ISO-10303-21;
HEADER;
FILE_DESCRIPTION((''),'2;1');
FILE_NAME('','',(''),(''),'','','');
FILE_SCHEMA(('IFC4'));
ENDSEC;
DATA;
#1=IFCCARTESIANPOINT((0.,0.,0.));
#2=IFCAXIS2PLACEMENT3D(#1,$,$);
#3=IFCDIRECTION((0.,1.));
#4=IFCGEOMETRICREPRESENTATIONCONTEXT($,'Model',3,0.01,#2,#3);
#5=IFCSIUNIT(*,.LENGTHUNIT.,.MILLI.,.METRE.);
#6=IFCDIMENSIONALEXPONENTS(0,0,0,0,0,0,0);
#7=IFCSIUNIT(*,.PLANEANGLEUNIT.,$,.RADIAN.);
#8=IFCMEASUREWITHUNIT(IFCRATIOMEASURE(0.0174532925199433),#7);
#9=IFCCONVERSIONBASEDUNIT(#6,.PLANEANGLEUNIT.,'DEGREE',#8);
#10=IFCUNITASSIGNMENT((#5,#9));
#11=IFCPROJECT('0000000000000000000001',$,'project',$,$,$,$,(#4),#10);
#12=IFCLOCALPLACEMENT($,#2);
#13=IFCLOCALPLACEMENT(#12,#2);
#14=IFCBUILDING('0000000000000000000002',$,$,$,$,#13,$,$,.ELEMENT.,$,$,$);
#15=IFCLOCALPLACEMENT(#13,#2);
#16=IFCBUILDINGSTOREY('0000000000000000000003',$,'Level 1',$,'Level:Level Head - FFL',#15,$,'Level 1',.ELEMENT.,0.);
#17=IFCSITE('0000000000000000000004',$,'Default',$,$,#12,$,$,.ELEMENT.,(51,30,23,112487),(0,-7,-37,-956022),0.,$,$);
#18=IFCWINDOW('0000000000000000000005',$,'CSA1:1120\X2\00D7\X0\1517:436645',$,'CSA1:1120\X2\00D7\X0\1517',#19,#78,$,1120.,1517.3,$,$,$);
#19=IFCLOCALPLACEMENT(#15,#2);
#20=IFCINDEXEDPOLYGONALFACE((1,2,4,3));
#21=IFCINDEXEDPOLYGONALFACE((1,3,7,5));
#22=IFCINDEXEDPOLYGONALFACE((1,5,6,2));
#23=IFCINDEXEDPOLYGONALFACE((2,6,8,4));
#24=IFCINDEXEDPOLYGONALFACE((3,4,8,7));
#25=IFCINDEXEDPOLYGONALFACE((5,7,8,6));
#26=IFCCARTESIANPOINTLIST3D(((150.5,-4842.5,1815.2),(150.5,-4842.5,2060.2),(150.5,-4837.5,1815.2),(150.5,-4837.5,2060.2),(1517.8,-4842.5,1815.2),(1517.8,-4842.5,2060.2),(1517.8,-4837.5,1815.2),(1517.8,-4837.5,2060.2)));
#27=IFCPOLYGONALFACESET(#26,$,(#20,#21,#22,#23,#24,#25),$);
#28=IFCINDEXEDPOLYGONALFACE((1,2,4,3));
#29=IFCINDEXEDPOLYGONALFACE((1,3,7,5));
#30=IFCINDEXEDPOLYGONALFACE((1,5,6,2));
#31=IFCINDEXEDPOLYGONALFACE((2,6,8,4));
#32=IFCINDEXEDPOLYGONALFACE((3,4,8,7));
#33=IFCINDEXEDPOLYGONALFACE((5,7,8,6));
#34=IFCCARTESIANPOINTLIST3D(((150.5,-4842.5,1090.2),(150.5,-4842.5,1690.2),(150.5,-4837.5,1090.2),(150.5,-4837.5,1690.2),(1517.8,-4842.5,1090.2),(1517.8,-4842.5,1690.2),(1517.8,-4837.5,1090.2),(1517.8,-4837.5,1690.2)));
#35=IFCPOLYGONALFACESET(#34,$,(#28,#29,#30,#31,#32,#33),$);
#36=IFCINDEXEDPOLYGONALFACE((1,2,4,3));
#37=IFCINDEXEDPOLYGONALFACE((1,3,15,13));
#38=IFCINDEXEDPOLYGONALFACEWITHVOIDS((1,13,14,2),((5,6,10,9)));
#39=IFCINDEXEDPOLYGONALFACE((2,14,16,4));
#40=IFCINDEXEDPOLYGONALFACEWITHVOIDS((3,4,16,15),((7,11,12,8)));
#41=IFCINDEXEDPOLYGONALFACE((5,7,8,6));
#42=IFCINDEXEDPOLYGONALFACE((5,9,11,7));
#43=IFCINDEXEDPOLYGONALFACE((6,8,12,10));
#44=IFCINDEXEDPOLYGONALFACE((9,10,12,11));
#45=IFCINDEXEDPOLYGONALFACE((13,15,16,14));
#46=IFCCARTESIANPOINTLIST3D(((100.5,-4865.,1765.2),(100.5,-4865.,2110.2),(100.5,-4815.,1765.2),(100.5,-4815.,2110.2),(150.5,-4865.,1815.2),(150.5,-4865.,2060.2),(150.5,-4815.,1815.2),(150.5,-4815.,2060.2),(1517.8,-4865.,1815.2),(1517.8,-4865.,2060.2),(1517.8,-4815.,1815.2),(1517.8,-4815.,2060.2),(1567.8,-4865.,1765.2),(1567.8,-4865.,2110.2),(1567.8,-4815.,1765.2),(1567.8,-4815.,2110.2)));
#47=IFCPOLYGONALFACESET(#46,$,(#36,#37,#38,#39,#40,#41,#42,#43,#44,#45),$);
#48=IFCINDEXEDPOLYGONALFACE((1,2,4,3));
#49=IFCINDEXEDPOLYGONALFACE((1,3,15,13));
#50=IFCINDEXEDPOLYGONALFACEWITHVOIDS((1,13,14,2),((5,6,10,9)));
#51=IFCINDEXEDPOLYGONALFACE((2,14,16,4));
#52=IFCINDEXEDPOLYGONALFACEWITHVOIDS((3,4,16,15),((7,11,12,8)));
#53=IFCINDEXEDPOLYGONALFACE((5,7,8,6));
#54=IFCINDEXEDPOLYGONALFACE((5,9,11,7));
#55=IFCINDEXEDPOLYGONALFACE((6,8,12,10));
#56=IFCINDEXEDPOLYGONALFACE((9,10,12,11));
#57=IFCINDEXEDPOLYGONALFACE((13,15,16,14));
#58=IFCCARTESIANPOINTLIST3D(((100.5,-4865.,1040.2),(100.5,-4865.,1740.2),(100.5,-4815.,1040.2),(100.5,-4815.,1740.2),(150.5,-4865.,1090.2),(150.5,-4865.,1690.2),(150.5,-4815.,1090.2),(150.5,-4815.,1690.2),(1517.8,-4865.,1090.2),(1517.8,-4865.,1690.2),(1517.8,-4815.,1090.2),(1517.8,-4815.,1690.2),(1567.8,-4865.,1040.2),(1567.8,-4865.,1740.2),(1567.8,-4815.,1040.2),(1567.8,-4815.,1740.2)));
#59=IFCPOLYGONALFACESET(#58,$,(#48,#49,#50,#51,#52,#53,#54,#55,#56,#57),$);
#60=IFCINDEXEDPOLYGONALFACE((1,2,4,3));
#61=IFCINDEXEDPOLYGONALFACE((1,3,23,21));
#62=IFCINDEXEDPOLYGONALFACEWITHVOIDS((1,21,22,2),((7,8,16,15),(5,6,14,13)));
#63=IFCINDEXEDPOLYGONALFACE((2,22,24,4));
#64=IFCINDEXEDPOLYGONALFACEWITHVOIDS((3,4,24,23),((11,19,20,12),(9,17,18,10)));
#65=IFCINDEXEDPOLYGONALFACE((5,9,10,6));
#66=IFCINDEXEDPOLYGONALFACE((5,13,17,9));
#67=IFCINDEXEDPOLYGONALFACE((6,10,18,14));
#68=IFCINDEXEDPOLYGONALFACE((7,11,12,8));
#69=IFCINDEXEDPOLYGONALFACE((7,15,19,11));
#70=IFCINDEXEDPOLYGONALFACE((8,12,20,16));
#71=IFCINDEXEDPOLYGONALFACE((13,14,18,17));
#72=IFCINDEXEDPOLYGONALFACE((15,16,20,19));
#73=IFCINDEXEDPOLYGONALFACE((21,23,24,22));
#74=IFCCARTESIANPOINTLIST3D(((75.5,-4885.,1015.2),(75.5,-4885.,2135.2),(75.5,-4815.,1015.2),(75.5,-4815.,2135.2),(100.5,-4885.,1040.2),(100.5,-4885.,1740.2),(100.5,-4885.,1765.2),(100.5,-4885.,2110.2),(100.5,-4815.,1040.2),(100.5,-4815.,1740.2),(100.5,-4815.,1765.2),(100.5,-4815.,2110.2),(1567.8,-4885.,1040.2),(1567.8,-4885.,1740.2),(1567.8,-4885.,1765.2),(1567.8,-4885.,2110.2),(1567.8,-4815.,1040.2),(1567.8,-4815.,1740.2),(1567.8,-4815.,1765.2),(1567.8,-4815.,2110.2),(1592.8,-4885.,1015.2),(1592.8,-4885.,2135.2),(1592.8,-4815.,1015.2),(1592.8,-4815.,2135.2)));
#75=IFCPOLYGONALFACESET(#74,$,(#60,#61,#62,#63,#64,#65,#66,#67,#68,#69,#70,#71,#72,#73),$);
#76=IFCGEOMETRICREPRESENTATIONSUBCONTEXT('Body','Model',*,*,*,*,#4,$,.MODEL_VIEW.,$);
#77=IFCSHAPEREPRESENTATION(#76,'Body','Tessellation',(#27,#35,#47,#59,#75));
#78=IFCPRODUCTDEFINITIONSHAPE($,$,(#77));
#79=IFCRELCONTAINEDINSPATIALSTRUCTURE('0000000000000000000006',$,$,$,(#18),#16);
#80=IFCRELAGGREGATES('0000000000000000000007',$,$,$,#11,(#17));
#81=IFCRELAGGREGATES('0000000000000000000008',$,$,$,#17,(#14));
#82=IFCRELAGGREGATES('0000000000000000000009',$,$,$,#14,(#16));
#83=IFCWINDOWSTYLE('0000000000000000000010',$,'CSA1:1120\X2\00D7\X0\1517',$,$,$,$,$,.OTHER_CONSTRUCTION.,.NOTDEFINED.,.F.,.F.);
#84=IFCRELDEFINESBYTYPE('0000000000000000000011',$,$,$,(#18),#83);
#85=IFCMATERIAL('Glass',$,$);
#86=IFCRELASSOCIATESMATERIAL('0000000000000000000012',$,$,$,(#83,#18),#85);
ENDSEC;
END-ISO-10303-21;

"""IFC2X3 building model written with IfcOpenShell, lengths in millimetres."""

from ifc_helpers import new_model, entity, si_unit, converted_unit, direction, frame, origin, origin_2d_with_axis, place, context, subcontext, project, spatial, polyline, rectangle, outline, extrude, source, transform, mapped, material, type_object, type_shapes, element, save


model = new_model("IFC2X3")

# Units and contexts
model_context = context("Model", 3, precision=0.01, world=origin(), true_north=direction((0.0, 1.0)))
body_context = subcontext(model_context, "Body", "Model", "MODEL_VIEW")
ifc_project = project(units=[si_unit("LENGTHUNIT", "METRE", prefix="MILLI"), converted_unit("PLANEANGLEUNIT", "DEGREE", entity("IfcRatioMeasure", 0.0174532925199433), si_unit("PLANEANGLEUNIT", "RADIAN"), dimensions=[0, 0, 0, 0, 0, 0, 0])], contexts=[model_context])

# Site, building, storey
site_placement = place(None, origin())
site = spatial("IfcSite", under=ifc_project, at=site_placement, Name="Default", CompositionType="ELEMENT", RefLatitude=(51, 30, 23, 112487), RefLongitude=(0, -7, -37, -956022), RefElevation=0.0)
building_placement = place(site_placement, origin())
building = spatial("IfcBuilding", under=site, at=building_placement, CompositionType="ELEMENT")
storey_placement = place(building_placement, origin())
storey = spatial("IfcBuildingStorey", under=building, at=storey_placement, Name="Level 1", ObjectType="Level:Level Head - FFL", LongName="Level 1", CompositionType="ELEMENT", Elevation=0.0)

# Window
ifc_material_1 = material(Name="Glass")
window_style_1 = type_object("IfcWindowStyle", Name="CSA1:1120×1517", ConstructionType="OTHER_CONSTRUCTION", OperationType="NOTDEFINED", ParameterTakesPrecedence=False, Sizeable=False, material=ifc_material_1)
shared_shape_1 = source(origin(), body_context, "Body", "SweptSolid", [
    extrude(rectangle(XDim=5.0, YDim=1367.3, at=origin_2d_with_axis()), frame((758.6, 45.0, 800.0), z_axis=(0.0, 0.0, 1.0), x_axis=(0.0, 1.0, 0.0)), (0.0, 0.0, 1.0), 245.0),
    extrude(rectangle(XDim=5.0, YDim=1367.3, at=origin_2d_with_axis()), frame((758.6, 45.0, 75.0), z_axis=(0.0, 0.0, 1.0), x_axis=(0.0, 1.0, 0.0)), (0.0, 0.0, 1.0), 600.0),
    extrude(outline(polyline([(-733.6, -172.5), (733.6, -172.5), (733.6, 172.5), (-733.6, 172.5), (-733.6, -172.5)]), holes=[polyline([(-683.6, -122.5), (-683.6, 122.5), (683.6, 122.5), (683.6, -122.5), (-683.6, -122.5)])]), frame((758.6, 20.0, 922.5), z_axis=(0.0, 1.0, 0.0), x_axis=(1.0, 0.0, 0.0)), (0.0, 0.0, 1.0), 50.0),
    extrude(outline(polyline([(-733.6, -350.0), (733.6, -350.0), (733.6, 350.0), (-733.6, 350.0), (-733.6, -350.0)]), holes=[polyline([(-683.6, -300.0), (-683.6, 300.0), (683.6, 300.0), (683.6, -300.0), (-683.6, -300.0)])]), frame((758.6, 20.0, 375.0), z_axis=(0.0, 1.0, 0.0), x_axis=(1.0, 0.0, 0.0)), (0.0, 0.0, 1.0), 50.0),
    extrude(outline(polyline([(-758.6, -560.0), (758.6, -560.0), (758.6, 560.0), (-758.6, 560.0), (-758.6, -560.0)]), holes=[polyline([(-733.6, -535.0), (-733.6, -190.0), (733.6, -190.0), (733.6, -535.0), (-733.6, -535.0)]), polyline([(-733.6, -165.0), (-733.6, 535.0), (733.6, 535.0), (733.6, -165.0), (-733.6, -165.0)])]), frame((758.6, 0.0, 560.0), z_axis=(0.0, 1.0, 0.0), x_axis=(1.0, 0.0, 0.0)), (0.0, 0.0, 1.0), 70.0),
])
type_shapes(window_style_1, [shared_shape_1])
window_1_placement = place(storey_placement, frame((75.5, -4885.0, 1015.2)))
element("IfcWindow", 1, at=window_1_placement, inside=storey, type_object=window_style_1, material=ifc_material_1, Name="CSA1:1120×1517:436645", ObjectType="CSA1:1120×1517", OverallHeight=1120.0, OverallWidth=1517.3, context=body_context, shape_type="MappedRepresentation", body=[
    mapped(shared_shape_1, transform((0.0, 0.0, 0.0), scale=1.0)),
])

save(model, "model.ifc")
